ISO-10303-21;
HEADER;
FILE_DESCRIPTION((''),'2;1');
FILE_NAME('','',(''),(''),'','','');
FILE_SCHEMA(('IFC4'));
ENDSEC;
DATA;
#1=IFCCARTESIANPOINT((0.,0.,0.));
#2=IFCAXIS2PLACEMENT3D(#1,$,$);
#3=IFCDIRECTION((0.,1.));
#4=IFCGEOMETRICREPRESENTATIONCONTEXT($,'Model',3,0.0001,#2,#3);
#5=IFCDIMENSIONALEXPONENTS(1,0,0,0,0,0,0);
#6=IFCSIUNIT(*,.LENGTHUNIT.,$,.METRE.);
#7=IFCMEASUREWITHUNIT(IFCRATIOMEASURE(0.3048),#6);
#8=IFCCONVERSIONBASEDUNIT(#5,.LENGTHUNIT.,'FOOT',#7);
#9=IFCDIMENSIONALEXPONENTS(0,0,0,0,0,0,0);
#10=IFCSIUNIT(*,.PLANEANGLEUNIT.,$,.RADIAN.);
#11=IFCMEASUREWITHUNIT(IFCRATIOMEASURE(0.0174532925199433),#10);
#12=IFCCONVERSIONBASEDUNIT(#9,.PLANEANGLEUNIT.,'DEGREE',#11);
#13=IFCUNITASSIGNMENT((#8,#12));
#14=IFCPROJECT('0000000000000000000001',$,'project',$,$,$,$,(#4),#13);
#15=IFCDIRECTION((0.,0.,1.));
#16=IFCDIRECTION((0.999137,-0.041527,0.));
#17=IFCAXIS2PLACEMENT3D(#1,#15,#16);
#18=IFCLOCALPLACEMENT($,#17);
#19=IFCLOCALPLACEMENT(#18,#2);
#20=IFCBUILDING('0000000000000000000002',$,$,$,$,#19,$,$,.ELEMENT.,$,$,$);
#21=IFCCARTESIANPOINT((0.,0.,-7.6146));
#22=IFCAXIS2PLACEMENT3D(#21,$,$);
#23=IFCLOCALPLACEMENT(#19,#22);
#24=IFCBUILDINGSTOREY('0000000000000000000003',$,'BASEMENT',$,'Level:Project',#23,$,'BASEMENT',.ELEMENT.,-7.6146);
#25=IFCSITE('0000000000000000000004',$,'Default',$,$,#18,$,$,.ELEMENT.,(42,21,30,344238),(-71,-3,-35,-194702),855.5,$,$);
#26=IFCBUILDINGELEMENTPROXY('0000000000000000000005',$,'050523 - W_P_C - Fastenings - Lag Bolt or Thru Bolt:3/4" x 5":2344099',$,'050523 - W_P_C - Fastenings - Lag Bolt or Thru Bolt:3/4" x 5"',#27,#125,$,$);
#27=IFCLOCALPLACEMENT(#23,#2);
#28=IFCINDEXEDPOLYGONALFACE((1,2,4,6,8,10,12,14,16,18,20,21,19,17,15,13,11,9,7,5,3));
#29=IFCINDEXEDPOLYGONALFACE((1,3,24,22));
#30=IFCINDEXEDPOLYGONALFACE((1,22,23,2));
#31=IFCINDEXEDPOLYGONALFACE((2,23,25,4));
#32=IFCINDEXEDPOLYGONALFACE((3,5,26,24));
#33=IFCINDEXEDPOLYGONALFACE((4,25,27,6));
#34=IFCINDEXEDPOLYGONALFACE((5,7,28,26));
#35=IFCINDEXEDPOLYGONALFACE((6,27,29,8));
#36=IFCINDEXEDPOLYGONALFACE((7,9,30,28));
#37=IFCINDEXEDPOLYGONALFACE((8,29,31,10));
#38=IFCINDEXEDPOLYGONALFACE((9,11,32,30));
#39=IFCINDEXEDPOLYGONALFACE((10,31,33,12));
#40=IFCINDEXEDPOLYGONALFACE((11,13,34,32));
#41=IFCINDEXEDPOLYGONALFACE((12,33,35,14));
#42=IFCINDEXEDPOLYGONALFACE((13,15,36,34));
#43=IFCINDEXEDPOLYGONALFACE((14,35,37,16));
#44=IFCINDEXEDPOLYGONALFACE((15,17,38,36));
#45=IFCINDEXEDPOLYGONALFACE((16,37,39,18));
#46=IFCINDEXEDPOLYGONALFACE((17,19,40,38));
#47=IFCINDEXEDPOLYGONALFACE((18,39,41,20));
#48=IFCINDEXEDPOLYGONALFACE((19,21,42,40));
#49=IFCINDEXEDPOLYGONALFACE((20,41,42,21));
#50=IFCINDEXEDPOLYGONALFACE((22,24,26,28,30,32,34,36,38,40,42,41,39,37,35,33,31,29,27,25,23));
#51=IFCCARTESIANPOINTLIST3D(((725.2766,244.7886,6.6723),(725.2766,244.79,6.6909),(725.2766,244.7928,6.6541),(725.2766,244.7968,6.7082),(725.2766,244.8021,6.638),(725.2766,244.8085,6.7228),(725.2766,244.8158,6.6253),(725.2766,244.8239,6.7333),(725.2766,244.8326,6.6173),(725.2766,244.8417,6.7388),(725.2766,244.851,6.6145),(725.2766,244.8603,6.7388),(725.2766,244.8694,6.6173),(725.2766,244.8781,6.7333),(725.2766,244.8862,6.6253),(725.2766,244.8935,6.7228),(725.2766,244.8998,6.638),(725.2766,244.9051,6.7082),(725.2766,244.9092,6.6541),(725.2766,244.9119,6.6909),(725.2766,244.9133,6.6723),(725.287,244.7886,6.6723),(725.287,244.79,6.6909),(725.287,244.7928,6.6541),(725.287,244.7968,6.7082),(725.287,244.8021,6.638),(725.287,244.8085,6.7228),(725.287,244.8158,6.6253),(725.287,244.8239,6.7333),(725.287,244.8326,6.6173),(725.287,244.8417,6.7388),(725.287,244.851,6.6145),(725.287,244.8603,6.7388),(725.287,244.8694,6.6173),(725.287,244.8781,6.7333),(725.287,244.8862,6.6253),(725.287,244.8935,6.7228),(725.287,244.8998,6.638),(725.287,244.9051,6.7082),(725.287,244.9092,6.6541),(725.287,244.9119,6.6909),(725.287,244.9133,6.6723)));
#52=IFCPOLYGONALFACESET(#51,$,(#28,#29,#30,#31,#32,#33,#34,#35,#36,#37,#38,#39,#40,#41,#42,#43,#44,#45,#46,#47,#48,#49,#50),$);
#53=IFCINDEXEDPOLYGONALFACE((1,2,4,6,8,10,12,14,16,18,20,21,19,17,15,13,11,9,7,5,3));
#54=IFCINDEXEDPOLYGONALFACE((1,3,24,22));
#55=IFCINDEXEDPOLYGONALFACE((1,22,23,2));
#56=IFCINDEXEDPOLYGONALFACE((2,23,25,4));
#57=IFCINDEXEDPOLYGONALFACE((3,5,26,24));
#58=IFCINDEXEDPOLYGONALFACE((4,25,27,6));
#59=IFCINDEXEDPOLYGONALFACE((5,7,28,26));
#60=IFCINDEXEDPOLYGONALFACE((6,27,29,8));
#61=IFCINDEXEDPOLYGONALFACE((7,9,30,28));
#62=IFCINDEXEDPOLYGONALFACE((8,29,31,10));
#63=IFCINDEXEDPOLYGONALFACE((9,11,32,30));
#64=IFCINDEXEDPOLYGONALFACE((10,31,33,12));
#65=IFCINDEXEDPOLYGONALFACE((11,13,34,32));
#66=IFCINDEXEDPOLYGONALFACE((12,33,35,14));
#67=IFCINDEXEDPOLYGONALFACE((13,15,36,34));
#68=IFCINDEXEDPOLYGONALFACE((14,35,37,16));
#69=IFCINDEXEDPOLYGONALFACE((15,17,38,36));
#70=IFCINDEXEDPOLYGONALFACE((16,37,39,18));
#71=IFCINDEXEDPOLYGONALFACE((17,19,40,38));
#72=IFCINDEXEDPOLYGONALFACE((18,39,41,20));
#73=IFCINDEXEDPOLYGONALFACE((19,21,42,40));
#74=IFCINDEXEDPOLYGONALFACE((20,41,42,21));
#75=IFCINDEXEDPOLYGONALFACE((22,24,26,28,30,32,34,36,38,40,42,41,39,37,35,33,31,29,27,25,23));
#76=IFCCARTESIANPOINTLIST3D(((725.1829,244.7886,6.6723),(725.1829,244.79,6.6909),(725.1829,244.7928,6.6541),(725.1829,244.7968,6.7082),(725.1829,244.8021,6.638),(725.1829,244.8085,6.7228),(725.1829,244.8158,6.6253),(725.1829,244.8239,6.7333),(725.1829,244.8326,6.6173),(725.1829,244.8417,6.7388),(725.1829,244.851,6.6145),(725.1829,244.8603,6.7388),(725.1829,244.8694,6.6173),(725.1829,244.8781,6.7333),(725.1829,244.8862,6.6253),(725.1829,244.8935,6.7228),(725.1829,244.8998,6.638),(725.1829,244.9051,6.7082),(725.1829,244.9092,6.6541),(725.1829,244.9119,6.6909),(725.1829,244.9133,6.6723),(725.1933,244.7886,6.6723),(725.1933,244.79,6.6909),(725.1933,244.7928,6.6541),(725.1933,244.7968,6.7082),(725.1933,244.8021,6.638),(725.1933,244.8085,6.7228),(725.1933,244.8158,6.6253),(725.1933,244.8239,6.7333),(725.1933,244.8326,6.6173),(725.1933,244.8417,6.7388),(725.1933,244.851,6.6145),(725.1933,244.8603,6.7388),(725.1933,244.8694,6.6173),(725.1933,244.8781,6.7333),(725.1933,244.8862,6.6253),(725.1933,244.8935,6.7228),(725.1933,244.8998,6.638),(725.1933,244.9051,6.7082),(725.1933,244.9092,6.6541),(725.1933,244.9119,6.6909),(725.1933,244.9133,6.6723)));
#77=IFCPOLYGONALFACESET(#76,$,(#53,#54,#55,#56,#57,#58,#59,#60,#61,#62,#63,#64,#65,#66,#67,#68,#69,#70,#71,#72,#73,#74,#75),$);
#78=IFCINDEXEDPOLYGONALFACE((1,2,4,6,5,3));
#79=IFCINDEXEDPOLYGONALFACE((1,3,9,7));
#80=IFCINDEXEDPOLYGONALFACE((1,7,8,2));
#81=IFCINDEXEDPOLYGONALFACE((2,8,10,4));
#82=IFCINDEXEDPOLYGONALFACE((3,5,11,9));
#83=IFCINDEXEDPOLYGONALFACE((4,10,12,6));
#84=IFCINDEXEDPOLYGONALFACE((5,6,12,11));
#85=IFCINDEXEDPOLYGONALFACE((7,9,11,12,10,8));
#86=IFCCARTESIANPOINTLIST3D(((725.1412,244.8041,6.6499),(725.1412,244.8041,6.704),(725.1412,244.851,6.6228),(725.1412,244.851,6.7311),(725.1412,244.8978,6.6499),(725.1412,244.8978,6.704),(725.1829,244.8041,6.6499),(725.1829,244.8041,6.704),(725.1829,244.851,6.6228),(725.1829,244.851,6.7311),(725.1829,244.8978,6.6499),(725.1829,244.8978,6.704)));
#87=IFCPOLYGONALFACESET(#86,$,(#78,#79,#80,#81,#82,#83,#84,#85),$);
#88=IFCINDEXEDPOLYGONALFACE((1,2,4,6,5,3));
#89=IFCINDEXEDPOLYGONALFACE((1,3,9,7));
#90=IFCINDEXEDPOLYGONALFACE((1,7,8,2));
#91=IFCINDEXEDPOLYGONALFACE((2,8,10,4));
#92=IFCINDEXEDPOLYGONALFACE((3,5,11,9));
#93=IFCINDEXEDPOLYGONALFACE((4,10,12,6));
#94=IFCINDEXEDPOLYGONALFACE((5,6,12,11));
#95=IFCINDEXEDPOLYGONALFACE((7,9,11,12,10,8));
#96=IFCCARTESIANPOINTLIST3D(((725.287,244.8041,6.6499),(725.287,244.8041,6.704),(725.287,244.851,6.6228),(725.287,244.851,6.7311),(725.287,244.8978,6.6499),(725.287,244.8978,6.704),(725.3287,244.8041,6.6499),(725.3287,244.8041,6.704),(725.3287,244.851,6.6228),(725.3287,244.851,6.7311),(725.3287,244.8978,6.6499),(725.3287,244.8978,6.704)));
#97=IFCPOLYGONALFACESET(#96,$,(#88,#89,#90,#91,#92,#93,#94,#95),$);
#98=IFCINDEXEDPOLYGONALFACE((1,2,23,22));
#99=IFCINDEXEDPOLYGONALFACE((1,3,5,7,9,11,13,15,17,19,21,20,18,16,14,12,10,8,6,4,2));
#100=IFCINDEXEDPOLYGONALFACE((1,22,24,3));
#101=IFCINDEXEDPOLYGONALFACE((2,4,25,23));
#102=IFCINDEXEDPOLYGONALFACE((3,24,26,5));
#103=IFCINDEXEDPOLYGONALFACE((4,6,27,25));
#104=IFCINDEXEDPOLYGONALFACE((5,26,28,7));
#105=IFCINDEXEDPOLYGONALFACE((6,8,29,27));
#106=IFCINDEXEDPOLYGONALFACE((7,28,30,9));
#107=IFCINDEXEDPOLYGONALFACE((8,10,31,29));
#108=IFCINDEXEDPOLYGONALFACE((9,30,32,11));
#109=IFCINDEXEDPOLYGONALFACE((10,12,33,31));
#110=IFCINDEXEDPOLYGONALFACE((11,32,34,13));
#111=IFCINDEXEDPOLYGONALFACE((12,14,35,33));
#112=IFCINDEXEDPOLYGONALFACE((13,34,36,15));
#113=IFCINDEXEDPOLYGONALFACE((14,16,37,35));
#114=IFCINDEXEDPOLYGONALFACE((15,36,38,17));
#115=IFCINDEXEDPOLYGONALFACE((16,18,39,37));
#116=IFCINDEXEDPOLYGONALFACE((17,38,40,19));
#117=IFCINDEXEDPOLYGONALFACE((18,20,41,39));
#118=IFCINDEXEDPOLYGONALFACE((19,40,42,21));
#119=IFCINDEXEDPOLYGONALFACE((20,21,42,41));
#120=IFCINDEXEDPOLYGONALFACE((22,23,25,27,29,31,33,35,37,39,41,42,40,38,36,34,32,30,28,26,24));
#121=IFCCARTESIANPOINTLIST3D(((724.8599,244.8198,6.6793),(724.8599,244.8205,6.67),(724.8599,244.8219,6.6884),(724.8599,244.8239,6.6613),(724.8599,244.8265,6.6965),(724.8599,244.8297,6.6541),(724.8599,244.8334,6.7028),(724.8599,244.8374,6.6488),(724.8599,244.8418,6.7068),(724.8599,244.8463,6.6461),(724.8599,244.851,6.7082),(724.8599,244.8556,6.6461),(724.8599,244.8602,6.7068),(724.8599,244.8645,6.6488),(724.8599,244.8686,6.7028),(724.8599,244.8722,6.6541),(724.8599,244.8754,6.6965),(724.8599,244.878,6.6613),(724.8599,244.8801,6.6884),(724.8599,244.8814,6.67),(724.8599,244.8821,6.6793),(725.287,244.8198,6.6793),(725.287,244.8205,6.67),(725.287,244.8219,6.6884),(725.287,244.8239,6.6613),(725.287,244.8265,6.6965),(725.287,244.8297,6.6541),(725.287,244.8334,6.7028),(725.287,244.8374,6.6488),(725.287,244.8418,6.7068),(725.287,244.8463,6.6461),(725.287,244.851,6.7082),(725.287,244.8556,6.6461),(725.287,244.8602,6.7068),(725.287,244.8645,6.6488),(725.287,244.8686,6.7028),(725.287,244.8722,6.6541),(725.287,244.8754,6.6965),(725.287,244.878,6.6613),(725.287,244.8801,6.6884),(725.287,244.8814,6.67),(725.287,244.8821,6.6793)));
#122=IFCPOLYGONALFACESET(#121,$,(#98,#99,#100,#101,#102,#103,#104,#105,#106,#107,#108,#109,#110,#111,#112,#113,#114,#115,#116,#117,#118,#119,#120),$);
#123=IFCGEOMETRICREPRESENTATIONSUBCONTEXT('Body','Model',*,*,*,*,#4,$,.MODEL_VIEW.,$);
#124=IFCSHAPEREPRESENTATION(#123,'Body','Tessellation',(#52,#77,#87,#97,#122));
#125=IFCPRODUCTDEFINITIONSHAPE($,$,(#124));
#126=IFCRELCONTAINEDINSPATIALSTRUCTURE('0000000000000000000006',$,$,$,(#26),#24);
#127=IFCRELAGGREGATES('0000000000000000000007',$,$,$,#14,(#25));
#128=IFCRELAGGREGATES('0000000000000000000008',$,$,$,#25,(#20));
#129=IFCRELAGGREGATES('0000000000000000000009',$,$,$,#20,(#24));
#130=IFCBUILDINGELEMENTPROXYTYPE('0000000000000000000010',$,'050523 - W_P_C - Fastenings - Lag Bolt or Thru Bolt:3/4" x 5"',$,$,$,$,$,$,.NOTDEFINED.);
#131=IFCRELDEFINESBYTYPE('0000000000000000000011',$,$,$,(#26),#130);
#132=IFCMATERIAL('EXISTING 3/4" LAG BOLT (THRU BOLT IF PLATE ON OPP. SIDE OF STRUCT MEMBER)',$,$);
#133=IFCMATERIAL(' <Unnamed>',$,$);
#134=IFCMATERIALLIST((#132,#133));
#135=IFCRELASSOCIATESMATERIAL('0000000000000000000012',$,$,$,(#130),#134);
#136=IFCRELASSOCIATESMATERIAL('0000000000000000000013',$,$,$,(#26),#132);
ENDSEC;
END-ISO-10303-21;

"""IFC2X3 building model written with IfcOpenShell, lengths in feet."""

from ifc_helpers import new_model, entity, si_unit, converted_unit, direction, frame, frame_2d, origin, place, context, subcontext, project, spatial, polyline, circle, outline, extrude, source, transform, mapped, material, material_list, type_object, type_shapes, element, save


model = new_model("IFC2X3")

# Units and contexts
model_context = context("Model", 3, precision=0.0001, world=origin(), true_north=direction((0.0, 1.0)))
body_context = subcontext(model_context, "Body", "Model", "MODEL_VIEW")
ifc_project = project(units=[converted_unit("LENGTHUNIT", "FOOT", entity("IfcRatioMeasure", 0.3048), si_unit("LENGTHUNIT", "METRE"), dimensions=[1, 0, 0, 0, 0, 0, 0]), converted_unit("PLANEANGLEUNIT", "DEGREE", entity("IfcRatioMeasure", 0.0174532925199433), si_unit("PLANEANGLEUNIT", "RADIAN"), dimensions=[0, 0, 0, 0, 0, 0, 0])], contexts=[model_context])

# Site, building, storey
site_placement = place(None, frame((0.0, 0.0, 0.0), z_axis=(0.0, 0.0, 1.0), x_axis=(0.999137, -0.041527, 0.0)))
site = spatial("IfcSite", under=ifc_project, at=site_placement, Name="Default", CompositionType="ELEMENT", RefLatitude=(42, 21, 30, 344238), RefLongitude=(-71, -3, -35, -194702), RefElevation=855.5)
building_placement = place(site_placement, origin())
building = spatial("IfcBuilding", under=site, at=building_placement, CompositionType="ELEMENT")
storey_placement = place(building_placement, frame((0.0, 0.0, -7.6146)))
storey = spatial("IfcBuildingStorey", under=building, at=storey_placement, Name="BASEMENT", ObjectType="Level:Project", LongName="BASEMENT", CompositionType="ELEMENT", Elevation=-7.6146)

# Building element proxy
ifc_material_1 = material(Name=" <Unnamed>")
ifc_material_2 = material(Name="EXISTING 3/4\" LAG BOLT (THRU BOLT IF PLATE ON OPP. SIDE OF STRUCT MEMBER)")
ifc_material_list_1 = material_list([ifc_material_2, ifc_material_1])
building_element_proxy_type_1 = type_object("IfcBuildingElementProxyType", Name="050523 - W_P_C - Fastenings - Lag Bolt or Thru Bolt:3/4\" x 5\"", PredefinedType="NOTDEFINED", material=ifc_material_list_1)
shared_shape_1 = source(origin(), body_context, "Body", "SweptSolid", [
    extrude(circle(Radius=0.0625, at=frame_2d((0.0, 0.0), x_axis=(1.0, 0.0))), frame((0.0, 0.0, 0.0), z_axis=(0.0, 0.0, 1.0), x_axis=(0.0, 1.0, 0.0)), (0.0, 0.0, 1.0), 0.0104),
    extrude(circle(Radius=0.0625, at=frame_2d((0.0, 0.0), x_axis=(1.0, 0.0))), frame((0.0, 0.0, -0.0938), z_axis=(0.0, 0.0, 1.0), x_axis=(0.0, 1.0, 0.0)), (0.0, 0.0, 1.0), 0.0104),
    extrude(outline(polyline([(-0.0271, -0.0469), (0.0271, -0.0469), (0.0541, 0.0), (0.0271, 0.0469), (-0.0271, 0.0469), (-0.0541, 0.0), (-0.0271, -0.0469)])), frame((0.0, 0.0, -0.1354), z_axis=(0.0, 0.0, 1.0), x_axis=(0.0, -1.0, 0.0)), (0.0, 0.0, 1.0), 0.0417),
    extrude(outline(polyline([(-0.0271, -0.0469), (0.0271, -0.0469), (0.0541, 0.0), (0.0271, 0.0469), (-0.0271, 0.0469), (-0.0541, 0.0), (-0.0271, -0.0469)])), frame((0.0, 0.0, 0.0104), z_axis=(0.0, 0.0, 1.0), x_axis=(0.866025, -0.5, 0.0)), (0.0, 0.0, 1.0), 0.0417),
    extrude(circle(Radius=0.0312, at=frame_2d((0.0, 0.0), x_axis=(1.0, 0.0))), frame((0.0, 0.0, -0.4167), z_axis=(0.0, 0.0, 1.0), x_axis=(0.0, -1.0, 0.0)), (0.0, 0.0, 1.0), 0.4271),
])
type_shapes(building_element_proxy_type_1, [shared_shape_1])
for number, where, z_axis, x_axis, name in (
    (1, (725.2766, 244.851, 6.677), (1.0, 0.0, 0.0), (0.0, -1.0, 0.0), "050523 - W_P_C - Fastenings - Lag Bolt or Thru Bolt:3/4\" x 5\":2344099"),
):
    element("IfcBuildingElementProxy", number, at=place(storey_placement, frame(where, z_axis=z_axis, x_axis=x_axis)), inside=storey, type_object=building_element_proxy_type_1, material=ifc_material_2, Name=name, ObjectType="050523 - W_P_C - Fastenings - Lag Bolt or Thru Bolt:3/4\" x 5\"", context=body_context, shape_type="MappedRepresentation", body=[
        mapped(shared_shape_1, transform((0.0, 0.0, 0.0), scale=1.0)),
    ])

save(model, "model.ifc")
